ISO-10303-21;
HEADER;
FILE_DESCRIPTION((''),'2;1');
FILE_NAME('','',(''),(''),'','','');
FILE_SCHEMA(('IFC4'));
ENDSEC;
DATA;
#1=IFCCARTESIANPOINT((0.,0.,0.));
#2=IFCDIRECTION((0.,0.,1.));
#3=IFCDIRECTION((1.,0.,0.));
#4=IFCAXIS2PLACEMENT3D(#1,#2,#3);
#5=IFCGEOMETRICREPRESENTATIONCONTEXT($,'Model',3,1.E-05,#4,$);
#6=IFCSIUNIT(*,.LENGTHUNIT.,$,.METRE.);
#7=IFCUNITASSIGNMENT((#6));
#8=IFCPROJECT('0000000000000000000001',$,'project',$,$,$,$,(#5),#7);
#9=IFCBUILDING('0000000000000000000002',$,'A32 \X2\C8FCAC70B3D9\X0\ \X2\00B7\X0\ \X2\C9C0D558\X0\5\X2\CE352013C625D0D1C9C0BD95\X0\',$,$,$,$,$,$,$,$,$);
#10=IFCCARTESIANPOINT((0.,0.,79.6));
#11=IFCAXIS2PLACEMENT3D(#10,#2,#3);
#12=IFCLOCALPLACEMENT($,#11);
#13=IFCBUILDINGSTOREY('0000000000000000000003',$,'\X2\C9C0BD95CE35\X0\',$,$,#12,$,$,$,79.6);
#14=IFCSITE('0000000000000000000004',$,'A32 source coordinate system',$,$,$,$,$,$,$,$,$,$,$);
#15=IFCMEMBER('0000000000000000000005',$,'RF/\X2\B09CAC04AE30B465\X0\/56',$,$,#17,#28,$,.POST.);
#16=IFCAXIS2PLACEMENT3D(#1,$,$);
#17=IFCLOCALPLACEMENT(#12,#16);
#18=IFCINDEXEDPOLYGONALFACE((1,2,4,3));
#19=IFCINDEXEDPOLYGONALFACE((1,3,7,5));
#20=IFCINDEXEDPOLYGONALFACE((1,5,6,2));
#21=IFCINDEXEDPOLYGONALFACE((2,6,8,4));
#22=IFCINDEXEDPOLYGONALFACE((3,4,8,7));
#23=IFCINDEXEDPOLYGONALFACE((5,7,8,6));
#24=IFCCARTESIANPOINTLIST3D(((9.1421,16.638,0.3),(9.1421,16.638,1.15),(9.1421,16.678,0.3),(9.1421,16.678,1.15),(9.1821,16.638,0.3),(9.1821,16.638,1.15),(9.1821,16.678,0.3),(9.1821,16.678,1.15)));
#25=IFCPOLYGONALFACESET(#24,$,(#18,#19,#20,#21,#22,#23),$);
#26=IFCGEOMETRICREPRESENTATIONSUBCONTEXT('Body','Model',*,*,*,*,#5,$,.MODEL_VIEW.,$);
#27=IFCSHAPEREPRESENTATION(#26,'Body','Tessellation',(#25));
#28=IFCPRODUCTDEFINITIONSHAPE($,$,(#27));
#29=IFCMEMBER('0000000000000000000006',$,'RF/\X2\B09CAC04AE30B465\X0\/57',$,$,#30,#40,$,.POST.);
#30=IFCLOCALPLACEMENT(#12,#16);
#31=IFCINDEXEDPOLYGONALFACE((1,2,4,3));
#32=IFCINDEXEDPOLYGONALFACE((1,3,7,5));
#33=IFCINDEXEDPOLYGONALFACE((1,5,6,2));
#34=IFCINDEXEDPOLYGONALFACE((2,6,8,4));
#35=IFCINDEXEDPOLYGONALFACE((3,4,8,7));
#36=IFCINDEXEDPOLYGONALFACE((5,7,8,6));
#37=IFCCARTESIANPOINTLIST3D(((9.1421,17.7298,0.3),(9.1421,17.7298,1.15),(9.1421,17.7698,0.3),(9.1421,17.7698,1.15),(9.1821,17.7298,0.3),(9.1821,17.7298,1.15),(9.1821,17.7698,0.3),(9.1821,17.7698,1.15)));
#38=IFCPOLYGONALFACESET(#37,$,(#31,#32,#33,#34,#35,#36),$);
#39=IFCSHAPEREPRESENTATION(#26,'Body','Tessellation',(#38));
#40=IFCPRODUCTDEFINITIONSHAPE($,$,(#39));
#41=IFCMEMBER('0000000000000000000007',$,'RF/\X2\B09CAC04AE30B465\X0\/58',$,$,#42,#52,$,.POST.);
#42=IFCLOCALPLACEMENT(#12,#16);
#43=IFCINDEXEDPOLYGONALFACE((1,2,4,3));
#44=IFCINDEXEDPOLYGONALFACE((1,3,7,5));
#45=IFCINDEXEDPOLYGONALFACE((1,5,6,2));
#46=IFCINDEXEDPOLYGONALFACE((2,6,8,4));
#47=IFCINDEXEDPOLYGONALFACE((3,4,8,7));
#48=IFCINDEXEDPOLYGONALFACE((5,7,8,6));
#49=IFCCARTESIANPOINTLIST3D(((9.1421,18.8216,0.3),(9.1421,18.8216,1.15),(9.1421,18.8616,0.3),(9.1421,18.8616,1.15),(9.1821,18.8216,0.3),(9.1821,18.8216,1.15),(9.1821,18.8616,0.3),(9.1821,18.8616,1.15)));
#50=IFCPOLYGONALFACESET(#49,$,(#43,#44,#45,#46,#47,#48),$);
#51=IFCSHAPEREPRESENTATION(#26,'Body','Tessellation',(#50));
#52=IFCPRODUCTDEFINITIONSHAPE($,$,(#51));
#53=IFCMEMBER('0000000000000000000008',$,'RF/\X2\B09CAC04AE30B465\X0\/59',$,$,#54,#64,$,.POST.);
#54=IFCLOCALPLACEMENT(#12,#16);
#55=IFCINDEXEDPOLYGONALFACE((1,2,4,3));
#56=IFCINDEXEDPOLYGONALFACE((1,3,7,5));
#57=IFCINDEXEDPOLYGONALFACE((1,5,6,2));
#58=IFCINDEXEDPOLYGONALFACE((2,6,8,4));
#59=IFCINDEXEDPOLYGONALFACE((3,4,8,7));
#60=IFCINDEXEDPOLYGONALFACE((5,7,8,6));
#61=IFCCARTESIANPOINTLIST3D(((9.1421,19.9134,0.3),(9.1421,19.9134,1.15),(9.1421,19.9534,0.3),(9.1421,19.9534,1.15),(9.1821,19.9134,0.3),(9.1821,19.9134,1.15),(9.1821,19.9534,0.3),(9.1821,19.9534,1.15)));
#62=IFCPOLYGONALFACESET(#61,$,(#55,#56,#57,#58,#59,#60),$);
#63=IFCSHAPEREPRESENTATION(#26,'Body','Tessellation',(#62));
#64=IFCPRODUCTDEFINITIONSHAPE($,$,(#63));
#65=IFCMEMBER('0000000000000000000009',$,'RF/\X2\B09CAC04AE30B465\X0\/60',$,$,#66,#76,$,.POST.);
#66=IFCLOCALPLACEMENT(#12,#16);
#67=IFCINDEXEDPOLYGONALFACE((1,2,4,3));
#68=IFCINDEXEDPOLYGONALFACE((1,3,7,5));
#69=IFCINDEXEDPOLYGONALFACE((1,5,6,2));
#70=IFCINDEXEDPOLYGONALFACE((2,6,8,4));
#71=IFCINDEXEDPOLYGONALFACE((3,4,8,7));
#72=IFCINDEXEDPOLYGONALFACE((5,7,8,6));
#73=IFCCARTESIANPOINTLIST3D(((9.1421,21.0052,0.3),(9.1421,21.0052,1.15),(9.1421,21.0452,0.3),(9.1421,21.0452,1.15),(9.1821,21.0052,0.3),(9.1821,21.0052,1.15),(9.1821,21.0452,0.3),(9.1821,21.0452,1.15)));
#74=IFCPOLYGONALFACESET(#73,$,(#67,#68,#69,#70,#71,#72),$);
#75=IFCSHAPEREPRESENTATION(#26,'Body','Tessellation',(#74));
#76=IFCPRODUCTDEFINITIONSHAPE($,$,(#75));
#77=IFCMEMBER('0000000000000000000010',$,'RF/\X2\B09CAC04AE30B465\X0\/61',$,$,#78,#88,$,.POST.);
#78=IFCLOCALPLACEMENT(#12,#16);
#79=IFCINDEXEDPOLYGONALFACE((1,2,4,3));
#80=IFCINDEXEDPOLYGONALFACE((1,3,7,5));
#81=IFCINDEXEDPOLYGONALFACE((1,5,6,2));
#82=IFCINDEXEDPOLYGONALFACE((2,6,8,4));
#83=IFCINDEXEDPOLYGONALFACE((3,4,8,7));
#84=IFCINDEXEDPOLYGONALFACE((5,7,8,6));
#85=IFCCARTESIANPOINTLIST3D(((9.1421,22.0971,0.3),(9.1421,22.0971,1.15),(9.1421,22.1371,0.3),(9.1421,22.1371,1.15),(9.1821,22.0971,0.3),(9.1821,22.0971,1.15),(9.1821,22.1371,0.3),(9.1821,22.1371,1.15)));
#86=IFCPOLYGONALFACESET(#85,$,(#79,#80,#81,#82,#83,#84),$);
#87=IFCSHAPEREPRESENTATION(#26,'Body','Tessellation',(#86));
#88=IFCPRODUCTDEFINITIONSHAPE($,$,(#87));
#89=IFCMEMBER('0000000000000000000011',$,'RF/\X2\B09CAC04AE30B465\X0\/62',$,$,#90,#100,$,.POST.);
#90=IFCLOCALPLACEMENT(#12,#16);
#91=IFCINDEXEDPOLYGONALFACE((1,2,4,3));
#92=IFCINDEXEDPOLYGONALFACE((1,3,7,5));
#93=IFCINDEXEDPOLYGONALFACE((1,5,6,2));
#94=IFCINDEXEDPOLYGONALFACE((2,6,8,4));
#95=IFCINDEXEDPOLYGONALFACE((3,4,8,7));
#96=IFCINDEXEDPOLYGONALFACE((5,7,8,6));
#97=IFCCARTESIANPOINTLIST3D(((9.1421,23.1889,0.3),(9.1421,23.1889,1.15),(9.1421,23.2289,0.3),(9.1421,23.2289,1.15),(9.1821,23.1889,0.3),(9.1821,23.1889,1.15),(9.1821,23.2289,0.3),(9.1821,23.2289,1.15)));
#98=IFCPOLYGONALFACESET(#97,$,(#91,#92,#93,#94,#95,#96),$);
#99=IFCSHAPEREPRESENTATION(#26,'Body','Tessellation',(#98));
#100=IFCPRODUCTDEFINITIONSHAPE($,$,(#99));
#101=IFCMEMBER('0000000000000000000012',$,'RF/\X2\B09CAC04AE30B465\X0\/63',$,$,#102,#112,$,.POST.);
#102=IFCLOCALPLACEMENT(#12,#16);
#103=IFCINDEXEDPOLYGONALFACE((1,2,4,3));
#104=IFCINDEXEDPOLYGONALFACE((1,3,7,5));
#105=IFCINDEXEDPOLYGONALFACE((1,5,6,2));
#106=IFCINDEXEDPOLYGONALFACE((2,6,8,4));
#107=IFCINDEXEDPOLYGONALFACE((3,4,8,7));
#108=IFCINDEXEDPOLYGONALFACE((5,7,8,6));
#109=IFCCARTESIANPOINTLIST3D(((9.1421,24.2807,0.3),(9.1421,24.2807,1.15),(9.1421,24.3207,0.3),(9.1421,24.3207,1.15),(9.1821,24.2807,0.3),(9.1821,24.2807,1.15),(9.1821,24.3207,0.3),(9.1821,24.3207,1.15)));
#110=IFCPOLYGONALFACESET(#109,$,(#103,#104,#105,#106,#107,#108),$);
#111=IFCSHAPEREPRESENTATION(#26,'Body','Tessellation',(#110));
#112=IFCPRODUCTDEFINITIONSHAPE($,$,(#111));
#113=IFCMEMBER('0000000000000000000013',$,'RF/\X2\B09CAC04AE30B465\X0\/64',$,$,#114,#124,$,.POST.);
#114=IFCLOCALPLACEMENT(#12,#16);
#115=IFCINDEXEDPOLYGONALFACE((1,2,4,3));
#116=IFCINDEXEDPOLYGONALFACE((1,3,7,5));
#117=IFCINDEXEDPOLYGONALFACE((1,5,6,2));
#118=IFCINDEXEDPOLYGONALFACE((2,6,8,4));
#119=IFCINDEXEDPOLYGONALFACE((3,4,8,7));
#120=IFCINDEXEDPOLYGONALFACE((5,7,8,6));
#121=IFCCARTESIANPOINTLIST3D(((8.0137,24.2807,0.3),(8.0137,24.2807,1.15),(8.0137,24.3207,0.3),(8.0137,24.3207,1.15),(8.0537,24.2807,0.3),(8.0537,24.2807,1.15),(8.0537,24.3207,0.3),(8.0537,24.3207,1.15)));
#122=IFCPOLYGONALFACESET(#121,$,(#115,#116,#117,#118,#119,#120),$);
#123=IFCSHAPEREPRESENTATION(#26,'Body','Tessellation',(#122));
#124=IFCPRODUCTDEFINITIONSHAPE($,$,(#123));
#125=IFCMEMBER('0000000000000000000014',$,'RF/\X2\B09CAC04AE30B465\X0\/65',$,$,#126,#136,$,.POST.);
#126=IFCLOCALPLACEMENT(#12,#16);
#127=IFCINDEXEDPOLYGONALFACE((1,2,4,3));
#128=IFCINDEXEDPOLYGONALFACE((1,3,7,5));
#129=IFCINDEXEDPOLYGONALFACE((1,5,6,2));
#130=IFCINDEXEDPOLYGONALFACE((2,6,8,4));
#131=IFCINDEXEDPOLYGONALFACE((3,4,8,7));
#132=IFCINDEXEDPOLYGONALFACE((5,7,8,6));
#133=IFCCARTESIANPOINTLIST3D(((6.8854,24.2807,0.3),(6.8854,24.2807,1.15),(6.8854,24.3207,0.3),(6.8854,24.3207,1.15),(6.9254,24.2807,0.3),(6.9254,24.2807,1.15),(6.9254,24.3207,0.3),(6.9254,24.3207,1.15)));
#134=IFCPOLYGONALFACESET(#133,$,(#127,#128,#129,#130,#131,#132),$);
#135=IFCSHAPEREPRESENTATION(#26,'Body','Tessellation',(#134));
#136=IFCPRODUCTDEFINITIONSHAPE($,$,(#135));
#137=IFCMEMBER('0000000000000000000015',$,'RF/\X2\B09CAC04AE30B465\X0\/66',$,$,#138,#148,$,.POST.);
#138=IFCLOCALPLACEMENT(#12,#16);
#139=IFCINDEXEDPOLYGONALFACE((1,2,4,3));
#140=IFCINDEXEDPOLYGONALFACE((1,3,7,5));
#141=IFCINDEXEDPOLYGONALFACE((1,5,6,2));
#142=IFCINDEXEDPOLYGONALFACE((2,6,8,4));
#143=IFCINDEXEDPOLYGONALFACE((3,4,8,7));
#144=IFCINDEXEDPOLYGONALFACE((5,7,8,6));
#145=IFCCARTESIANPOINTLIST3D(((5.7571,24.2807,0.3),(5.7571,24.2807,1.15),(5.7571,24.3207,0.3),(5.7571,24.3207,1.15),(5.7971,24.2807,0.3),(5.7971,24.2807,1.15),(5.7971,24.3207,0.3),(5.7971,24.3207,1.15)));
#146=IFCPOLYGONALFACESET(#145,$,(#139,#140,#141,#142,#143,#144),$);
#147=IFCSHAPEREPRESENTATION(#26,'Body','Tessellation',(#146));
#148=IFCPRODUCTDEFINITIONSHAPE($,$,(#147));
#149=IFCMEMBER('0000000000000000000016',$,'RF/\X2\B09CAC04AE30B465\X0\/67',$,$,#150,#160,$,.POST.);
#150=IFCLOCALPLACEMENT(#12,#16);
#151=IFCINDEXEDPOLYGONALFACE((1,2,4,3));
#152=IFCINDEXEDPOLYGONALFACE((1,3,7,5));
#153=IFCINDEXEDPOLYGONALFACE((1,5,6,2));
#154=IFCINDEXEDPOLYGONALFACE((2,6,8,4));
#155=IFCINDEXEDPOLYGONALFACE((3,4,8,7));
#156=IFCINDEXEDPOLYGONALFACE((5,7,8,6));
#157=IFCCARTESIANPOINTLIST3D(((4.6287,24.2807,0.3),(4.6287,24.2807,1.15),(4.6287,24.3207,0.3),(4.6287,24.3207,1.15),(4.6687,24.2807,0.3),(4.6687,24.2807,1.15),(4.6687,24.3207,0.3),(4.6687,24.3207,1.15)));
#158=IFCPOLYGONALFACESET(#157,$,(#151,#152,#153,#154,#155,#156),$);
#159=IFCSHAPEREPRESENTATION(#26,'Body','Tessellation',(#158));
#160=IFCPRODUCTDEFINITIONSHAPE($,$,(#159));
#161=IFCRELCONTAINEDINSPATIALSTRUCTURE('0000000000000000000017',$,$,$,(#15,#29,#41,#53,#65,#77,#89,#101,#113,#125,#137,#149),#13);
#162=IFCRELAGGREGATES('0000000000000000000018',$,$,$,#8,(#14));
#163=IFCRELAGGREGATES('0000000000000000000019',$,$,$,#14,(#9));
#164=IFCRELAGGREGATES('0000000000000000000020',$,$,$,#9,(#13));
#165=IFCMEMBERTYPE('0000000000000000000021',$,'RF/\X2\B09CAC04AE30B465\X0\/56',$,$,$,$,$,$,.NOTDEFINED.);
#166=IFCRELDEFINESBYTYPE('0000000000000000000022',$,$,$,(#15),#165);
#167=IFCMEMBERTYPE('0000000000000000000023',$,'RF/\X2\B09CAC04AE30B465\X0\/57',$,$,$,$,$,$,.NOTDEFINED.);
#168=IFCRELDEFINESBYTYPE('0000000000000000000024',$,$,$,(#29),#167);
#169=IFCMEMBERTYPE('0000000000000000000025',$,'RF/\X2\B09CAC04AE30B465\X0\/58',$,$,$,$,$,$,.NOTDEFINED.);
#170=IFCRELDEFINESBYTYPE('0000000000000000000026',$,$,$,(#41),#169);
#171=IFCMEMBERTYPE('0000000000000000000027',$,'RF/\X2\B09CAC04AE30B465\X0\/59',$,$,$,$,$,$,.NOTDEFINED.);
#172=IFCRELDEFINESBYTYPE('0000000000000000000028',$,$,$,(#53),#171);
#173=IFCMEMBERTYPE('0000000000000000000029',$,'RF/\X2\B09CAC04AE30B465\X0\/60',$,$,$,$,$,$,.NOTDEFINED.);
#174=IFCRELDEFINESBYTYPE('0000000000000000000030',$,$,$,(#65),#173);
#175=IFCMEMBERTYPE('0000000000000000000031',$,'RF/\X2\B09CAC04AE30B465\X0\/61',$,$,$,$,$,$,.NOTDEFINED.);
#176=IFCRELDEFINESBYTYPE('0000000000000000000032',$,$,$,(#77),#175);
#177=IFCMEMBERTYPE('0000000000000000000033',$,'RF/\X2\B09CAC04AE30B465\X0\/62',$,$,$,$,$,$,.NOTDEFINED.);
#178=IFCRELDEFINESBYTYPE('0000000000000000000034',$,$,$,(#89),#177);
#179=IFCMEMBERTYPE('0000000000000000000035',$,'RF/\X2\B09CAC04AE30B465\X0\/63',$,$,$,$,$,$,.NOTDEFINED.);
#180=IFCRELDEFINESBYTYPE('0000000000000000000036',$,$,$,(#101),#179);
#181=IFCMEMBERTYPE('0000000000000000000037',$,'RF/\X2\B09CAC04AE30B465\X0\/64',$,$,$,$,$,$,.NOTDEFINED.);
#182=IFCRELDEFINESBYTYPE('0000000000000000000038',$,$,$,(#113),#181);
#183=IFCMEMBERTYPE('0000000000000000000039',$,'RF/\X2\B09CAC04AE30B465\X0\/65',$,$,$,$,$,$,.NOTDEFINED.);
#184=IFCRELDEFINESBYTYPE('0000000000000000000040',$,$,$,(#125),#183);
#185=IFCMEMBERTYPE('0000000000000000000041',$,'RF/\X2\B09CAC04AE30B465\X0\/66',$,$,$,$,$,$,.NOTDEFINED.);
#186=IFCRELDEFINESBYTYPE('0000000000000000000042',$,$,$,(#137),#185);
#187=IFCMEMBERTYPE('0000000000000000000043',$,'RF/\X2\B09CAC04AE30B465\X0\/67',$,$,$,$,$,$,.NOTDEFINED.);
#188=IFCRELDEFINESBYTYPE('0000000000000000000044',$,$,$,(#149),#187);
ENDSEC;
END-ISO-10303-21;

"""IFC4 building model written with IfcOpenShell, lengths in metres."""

from ifc_helpers import new_model, si_unit, frame, origin, origin_with_axes, place, context, subcontext, project, spatial, polyline, outline, extrude, source, transform, mapped, type_object, type_shapes, element, save


model = new_model("IFC4")

# Units and contexts
model_context = context("Model", 3, precision=1e-05, world=origin_with_axes())
body_context = subcontext(model_context, "Body", "Model", "MODEL_VIEW")
ifc_project = project(units=[si_unit("LENGTHUNIT", "METRE")], contexts=[model_context])

# Site, building, storey
site = spatial("IfcSite", under=ifc_project, Name="A32 source coordinate system")
building = spatial("IfcBuilding", under=site, Name="A32 주거동 · 지하5층–옥탑지붕")
storey_placement = place(None, frame((0.0, 0.0, 79.6), z_axis=(0.0, 0.0, 1.0), x_axis=(1.0, 0.0, 0.0)))
storey = spatial("IfcBuildingStorey", under=building, at=storey_placement, Name="지붕층", Elevation=79.6)

# Members
member_type_1 = type_object("IfcMemberType", Name="RF/난간기둥/56", PredefinedType="NOTDEFINED")
shared_shape_1 = source(origin(), body_context, "Body", "SweptSolid", [
    extrude(outline(polyline([(9.1821, 16.638), (9.1421, 16.638), (9.1421, 16.678), (9.1821, 16.678), (9.1821, 16.638)])), frame((0.0, 0.0, 0.3)), (0.0, 0.0, 1.0), 0.85),
])
type_shapes(member_type_1, [shared_shape_1])
member_1_placement = place(storey_placement, origin_with_axes())
element("IfcMember", 1, at=member_1_placement, inside=storey, type_object=member_type_1, Name="RF/난간기둥/56", PredefinedType="POST", context=body_context, shape_type="MappedRepresentation", body=[
    mapped(shared_shape_1, transform((0.0, 0.0, 0.0), scale=1.0)),
])
member_type_2 = type_object("IfcMemberType", Name="RF/난간기둥/57", PredefinedType="NOTDEFINED")
shared_shape_2 = source(origin(), body_context, "Body", "SweptSolid", [
    extrude(outline(polyline([(9.1821, 17.7298), (9.1421, 17.7298), (9.1421, 17.7698), (9.1821, 17.7698), (9.1821, 17.7298)])), frame((0.0, 0.0, 0.3)), (0.0, 0.0, 1.0), 0.85),
])
type_shapes(member_type_2, [shared_shape_2])
member_2_placement = place(storey_placement, origin_with_axes())
element("IfcMember", 2, at=member_2_placement, inside=storey, type_object=member_type_2, Name="RF/난간기둥/57", PredefinedType="POST", context=body_context, shape_type="MappedRepresentation", body=[
    mapped(shared_shape_2, transform((0.0, 0.0, 0.0), scale=1.0)),
])
member_type_3 = type_object("IfcMemberType", Name="RF/난간기둥/58", PredefinedType="NOTDEFINED")
shared_shape_3 = source(origin(), body_context, "Body", "SweptSolid", [
    extrude(outline(polyline([(9.1821, 18.8216), (9.1421, 18.8216), (9.1421, 18.8616), (9.1821, 18.8616), (9.1821, 18.8216)])), frame((0.0, 0.0, 0.3)), (0.0, 0.0, 1.0), 0.85),
])
type_shapes(member_type_3, [shared_shape_3])
member_3_placement = place(storey_placement, origin_with_axes())
element("IfcMember", 3, at=member_3_placement, inside=storey, type_object=member_type_3, Name="RF/난간기둥/58", PredefinedType="POST", context=body_context, shape_type="MappedRepresentation", body=[
    mapped(shared_shape_3, transform((0.0, 0.0, 0.0), scale=1.0)),
])
member_type_4 = type_object("IfcMemberType", Name="RF/난간기둥/59", PredefinedType="NOTDEFINED")
shared_shape_4 = source(origin(), body_context, "Body", "SweptSolid", [
    extrude(outline(polyline([(9.1821, 19.9134), (9.1421, 19.9134), (9.1421, 19.9534), (9.1821, 19.9534), (9.1821, 19.9134)])), frame((0.0, 0.0, 0.3)), (0.0, 0.0, 1.0), 0.85),
])
type_shapes(member_type_4, [shared_shape_4])
member_4_placement = place(storey_placement, origin_with_axes())
element("IfcMember", 4, at=member_4_placement, inside=storey, type_object=member_type_4, Name="RF/난간기둥/59", PredefinedType="POST", context=body_context, shape_type="MappedRepresentation", body=[
    mapped(shared_shape_4, transform((0.0, 0.0, 0.0), scale=1.0)),
])
member_type_5 = type_object("IfcMemberType", Name="RF/난간기둥/60", PredefinedType="NOTDEFINED")
shared_shape_5 = source(origin(), body_context, "Body", "SweptSolid", [
    extrude(outline(polyline([(9.1821, 21.0052), (9.1421, 21.0052), (9.1421, 21.0452), (9.1821, 21.0452), (9.1821, 21.0052)])), frame((0.0, 0.0, 0.3)), (0.0, 0.0, 1.0), 0.85),
])
type_shapes(member_type_5, [shared_shape_5])
member_5_placement = place(storey_placement, origin_with_axes())
element("IfcMember", 5, at=member_5_placement, inside=storey, type_object=member_type_5, Name="RF/난간기둥/60", PredefinedType="POST", context=body_context, shape_type="MappedRepresentation", body=[
    mapped(shared_shape_5, transform((0.0, 0.0, 0.0), scale=1.0)),
])
member_type_6 = type_object("IfcMemberType", Name="RF/난간기둥/61", PredefinedType="NOTDEFINED")
shared_shape_6 = source(origin(), body_context, "Body", "SweptSolid", [
    extrude(outline(polyline([(9.1821, 22.0971), (9.1421, 22.0971), (9.1421, 22.1371), (9.1821, 22.1371), (9.1821, 22.0971)])), frame((0.0, 0.0, 0.3)), (0.0, 0.0, 1.0), 0.85),
])
type_shapes(member_type_6, [shared_shape_6])
member_6_placement = place(storey_placement, origin_with_axes())
element("IfcMember", 6, at=member_6_placement, inside=storey, type_object=member_type_6, Name="RF/난간기둥/61", PredefinedType="POST", context=body_context, shape_type="MappedRepresentation", body=[
    mapped(shared_shape_6, transform((0.0, 0.0, 0.0), scale=1.0)),
])
member_type_7 = type_object("IfcMemberType", Name="RF/난간기둥/62", PredefinedType="NOTDEFINED")
shared_shape_7 = source(origin(), body_context, "Body", "SweptSolid", [
    extrude(outline(polyline([(9.1821, 23.1889), (9.1421, 23.1889), (9.1421, 23.2289), (9.1821, 23.2289), (9.1821, 23.1889)])), frame((0.0, 0.0, 0.3)), (0.0, 0.0, 1.0), 0.85),
])
type_shapes(member_type_7, [shared_shape_7])
member_7_placement = place(storey_placement, origin_with_axes())
element("IfcMember", 7, at=member_7_placement, inside=storey, type_object=member_type_7, Name="RF/난간기둥/62", PredefinedType="POST", context=body_context, shape_type="MappedRepresentation", body=[
    mapped(shared_shape_7, transform((0.0, 0.0, 0.0), scale=1.0)),
])
member_type_8 = type_object("IfcMemberType", Name="RF/난간기둥/63", PredefinedType="NOTDEFINED")
shared_shape_8 = source(origin(), body_context, "Body", "SweptSolid", [
    extrude(outline(polyline([(9.1821, 24.2807), (9.1421, 24.2807), (9.1421, 24.3207), (9.1821, 24.3207), (9.1821, 24.2807)])), frame((0.0, 0.0, 0.3)), (0.0, 0.0, 1.0), 0.85),
])
type_shapes(member_type_8, [shared_shape_8])
member_8_placement = place(storey_placement, origin_with_axes())
element("IfcMember", 8, at=member_8_placement, inside=storey, type_object=member_type_8, Name="RF/난간기둥/63", PredefinedType="POST", context=body_context, shape_type="MappedRepresentation", body=[
    mapped(shared_shape_8, transform((0.0, 0.0, 0.0), scale=1.0)),
])
member_type_9 = type_object("IfcMemberType", Name="RF/난간기둥/64", PredefinedType="NOTDEFINED")
shared_shape_9 = source(origin(), body_context, "Body", "SweptSolid", [
    extrude(outline(polyline([(8.0537, 24.2807), (8.0137, 24.2807), (8.0137, 24.3207), (8.0537, 24.3207), (8.0537, 24.2807)])), frame((0.0, 0.0, 0.3)), (0.0, 0.0, 1.0), 0.85),
])
type_shapes(member_type_9, [shared_shape_9])
member_9_placement = place(storey_placement, origin_with_axes())
element("IfcMember", 9, at=member_9_placement, inside=storey, type_object=member_type_9, Name="RF/난간기둥/64", PredefinedType="POST", context=body_context, shape_type="MappedRepresentation", body=[
    mapped(shared_shape_9, transform((0.0, 0.0, 0.0), scale=1.0)),
])
member_type_10 = type_object("IfcMemberType", Name="RF/난간기둥/65", PredefinedType="NOTDEFINED")
shared_shape_10 = source(origin(), body_context, "Body", "SweptSolid", [
    extrude(outline(polyline([(6.9254, 24.2807), (6.8854, 24.2807), (6.8854, 24.3207), (6.9254, 24.3207), (6.9254, 24.2807)])), frame((0.0, 0.0, 0.3)), (0.0, 0.0, 1.0), 0.85),
])
type_shapes(member_type_10, [shared_shape_10])
member_10_placement = place(storey_placement, origin_with_axes())
element("IfcMember", 10, at=member_10_placement, inside=storey, type_object=member_type_10, Name="RF/난간기둥/65", PredefinedType="POST", context=body_context, shape_type="MappedRepresentation", body=[
    mapped(shared_shape_10, transform((0.0, 0.0, 0.0), scale=1.0)),
])
member_type_11 = type_object("IfcMemberType", Name="RF/난간기둥/66", PredefinedType="NOTDEFINED")
shared_shape_11 = source(origin(), body_context, "Body", "SweptSolid", [
    extrude(outline(polyline([(5.7971, 24.2807), (5.7571, 24.2807), (5.7571, 24.3207), (5.7971, 24.3207), (5.7971, 24.2807)])), frame((0.0, 0.0, 0.3)), (0.0, 0.0, 1.0), 0.85),
])
type_shapes(member_type_11, [shared_shape_11])
member_11_placement = place(storey_placement, origin_with_axes())
element("IfcMember", 11, at=member_11_placement, inside=storey, type_object=member_type_11, Name="RF/난간기둥/66", PredefinedType="POST", context=body_context, shape_type="MappedRepresentation", body=[
    mapped(shared_shape_11, transform((0.0, 0.0, 0.0), scale=1.0)),
])
member_type_12 = type_object("IfcMemberType", Name="RF/난간기둥/67", PredefinedType="NOTDEFINED")
shared_shape_12 = source(origin(), body_context, "Body", "SweptSolid", [
    extrude(outline(polyline([(4.6687, 24.2807), (4.6287, 24.2807), (4.6287, 24.3207), (4.6687, 24.3207), (4.6687, 24.2807)])), frame((0.0, 0.0, 0.3)), (0.0, 0.0, 1.0), 0.85),
])
type_shapes(member_type_12, [shared_shape_12])
member_12_placement = place(storey_placement, origin_with_axes())
element("IfcMember", 12, at=member_12_placement, inside=storey, type_object=member_type_12, Name="RF/난간기둥/67", PredefinedType="POST", context=body_context, shape_type="MappedRepresentation", body=[
    mapped(shared_shape_12, transform((0.0, 0.0, 0.0), scale=1.0)),
])

save(model, "model.ifc")
